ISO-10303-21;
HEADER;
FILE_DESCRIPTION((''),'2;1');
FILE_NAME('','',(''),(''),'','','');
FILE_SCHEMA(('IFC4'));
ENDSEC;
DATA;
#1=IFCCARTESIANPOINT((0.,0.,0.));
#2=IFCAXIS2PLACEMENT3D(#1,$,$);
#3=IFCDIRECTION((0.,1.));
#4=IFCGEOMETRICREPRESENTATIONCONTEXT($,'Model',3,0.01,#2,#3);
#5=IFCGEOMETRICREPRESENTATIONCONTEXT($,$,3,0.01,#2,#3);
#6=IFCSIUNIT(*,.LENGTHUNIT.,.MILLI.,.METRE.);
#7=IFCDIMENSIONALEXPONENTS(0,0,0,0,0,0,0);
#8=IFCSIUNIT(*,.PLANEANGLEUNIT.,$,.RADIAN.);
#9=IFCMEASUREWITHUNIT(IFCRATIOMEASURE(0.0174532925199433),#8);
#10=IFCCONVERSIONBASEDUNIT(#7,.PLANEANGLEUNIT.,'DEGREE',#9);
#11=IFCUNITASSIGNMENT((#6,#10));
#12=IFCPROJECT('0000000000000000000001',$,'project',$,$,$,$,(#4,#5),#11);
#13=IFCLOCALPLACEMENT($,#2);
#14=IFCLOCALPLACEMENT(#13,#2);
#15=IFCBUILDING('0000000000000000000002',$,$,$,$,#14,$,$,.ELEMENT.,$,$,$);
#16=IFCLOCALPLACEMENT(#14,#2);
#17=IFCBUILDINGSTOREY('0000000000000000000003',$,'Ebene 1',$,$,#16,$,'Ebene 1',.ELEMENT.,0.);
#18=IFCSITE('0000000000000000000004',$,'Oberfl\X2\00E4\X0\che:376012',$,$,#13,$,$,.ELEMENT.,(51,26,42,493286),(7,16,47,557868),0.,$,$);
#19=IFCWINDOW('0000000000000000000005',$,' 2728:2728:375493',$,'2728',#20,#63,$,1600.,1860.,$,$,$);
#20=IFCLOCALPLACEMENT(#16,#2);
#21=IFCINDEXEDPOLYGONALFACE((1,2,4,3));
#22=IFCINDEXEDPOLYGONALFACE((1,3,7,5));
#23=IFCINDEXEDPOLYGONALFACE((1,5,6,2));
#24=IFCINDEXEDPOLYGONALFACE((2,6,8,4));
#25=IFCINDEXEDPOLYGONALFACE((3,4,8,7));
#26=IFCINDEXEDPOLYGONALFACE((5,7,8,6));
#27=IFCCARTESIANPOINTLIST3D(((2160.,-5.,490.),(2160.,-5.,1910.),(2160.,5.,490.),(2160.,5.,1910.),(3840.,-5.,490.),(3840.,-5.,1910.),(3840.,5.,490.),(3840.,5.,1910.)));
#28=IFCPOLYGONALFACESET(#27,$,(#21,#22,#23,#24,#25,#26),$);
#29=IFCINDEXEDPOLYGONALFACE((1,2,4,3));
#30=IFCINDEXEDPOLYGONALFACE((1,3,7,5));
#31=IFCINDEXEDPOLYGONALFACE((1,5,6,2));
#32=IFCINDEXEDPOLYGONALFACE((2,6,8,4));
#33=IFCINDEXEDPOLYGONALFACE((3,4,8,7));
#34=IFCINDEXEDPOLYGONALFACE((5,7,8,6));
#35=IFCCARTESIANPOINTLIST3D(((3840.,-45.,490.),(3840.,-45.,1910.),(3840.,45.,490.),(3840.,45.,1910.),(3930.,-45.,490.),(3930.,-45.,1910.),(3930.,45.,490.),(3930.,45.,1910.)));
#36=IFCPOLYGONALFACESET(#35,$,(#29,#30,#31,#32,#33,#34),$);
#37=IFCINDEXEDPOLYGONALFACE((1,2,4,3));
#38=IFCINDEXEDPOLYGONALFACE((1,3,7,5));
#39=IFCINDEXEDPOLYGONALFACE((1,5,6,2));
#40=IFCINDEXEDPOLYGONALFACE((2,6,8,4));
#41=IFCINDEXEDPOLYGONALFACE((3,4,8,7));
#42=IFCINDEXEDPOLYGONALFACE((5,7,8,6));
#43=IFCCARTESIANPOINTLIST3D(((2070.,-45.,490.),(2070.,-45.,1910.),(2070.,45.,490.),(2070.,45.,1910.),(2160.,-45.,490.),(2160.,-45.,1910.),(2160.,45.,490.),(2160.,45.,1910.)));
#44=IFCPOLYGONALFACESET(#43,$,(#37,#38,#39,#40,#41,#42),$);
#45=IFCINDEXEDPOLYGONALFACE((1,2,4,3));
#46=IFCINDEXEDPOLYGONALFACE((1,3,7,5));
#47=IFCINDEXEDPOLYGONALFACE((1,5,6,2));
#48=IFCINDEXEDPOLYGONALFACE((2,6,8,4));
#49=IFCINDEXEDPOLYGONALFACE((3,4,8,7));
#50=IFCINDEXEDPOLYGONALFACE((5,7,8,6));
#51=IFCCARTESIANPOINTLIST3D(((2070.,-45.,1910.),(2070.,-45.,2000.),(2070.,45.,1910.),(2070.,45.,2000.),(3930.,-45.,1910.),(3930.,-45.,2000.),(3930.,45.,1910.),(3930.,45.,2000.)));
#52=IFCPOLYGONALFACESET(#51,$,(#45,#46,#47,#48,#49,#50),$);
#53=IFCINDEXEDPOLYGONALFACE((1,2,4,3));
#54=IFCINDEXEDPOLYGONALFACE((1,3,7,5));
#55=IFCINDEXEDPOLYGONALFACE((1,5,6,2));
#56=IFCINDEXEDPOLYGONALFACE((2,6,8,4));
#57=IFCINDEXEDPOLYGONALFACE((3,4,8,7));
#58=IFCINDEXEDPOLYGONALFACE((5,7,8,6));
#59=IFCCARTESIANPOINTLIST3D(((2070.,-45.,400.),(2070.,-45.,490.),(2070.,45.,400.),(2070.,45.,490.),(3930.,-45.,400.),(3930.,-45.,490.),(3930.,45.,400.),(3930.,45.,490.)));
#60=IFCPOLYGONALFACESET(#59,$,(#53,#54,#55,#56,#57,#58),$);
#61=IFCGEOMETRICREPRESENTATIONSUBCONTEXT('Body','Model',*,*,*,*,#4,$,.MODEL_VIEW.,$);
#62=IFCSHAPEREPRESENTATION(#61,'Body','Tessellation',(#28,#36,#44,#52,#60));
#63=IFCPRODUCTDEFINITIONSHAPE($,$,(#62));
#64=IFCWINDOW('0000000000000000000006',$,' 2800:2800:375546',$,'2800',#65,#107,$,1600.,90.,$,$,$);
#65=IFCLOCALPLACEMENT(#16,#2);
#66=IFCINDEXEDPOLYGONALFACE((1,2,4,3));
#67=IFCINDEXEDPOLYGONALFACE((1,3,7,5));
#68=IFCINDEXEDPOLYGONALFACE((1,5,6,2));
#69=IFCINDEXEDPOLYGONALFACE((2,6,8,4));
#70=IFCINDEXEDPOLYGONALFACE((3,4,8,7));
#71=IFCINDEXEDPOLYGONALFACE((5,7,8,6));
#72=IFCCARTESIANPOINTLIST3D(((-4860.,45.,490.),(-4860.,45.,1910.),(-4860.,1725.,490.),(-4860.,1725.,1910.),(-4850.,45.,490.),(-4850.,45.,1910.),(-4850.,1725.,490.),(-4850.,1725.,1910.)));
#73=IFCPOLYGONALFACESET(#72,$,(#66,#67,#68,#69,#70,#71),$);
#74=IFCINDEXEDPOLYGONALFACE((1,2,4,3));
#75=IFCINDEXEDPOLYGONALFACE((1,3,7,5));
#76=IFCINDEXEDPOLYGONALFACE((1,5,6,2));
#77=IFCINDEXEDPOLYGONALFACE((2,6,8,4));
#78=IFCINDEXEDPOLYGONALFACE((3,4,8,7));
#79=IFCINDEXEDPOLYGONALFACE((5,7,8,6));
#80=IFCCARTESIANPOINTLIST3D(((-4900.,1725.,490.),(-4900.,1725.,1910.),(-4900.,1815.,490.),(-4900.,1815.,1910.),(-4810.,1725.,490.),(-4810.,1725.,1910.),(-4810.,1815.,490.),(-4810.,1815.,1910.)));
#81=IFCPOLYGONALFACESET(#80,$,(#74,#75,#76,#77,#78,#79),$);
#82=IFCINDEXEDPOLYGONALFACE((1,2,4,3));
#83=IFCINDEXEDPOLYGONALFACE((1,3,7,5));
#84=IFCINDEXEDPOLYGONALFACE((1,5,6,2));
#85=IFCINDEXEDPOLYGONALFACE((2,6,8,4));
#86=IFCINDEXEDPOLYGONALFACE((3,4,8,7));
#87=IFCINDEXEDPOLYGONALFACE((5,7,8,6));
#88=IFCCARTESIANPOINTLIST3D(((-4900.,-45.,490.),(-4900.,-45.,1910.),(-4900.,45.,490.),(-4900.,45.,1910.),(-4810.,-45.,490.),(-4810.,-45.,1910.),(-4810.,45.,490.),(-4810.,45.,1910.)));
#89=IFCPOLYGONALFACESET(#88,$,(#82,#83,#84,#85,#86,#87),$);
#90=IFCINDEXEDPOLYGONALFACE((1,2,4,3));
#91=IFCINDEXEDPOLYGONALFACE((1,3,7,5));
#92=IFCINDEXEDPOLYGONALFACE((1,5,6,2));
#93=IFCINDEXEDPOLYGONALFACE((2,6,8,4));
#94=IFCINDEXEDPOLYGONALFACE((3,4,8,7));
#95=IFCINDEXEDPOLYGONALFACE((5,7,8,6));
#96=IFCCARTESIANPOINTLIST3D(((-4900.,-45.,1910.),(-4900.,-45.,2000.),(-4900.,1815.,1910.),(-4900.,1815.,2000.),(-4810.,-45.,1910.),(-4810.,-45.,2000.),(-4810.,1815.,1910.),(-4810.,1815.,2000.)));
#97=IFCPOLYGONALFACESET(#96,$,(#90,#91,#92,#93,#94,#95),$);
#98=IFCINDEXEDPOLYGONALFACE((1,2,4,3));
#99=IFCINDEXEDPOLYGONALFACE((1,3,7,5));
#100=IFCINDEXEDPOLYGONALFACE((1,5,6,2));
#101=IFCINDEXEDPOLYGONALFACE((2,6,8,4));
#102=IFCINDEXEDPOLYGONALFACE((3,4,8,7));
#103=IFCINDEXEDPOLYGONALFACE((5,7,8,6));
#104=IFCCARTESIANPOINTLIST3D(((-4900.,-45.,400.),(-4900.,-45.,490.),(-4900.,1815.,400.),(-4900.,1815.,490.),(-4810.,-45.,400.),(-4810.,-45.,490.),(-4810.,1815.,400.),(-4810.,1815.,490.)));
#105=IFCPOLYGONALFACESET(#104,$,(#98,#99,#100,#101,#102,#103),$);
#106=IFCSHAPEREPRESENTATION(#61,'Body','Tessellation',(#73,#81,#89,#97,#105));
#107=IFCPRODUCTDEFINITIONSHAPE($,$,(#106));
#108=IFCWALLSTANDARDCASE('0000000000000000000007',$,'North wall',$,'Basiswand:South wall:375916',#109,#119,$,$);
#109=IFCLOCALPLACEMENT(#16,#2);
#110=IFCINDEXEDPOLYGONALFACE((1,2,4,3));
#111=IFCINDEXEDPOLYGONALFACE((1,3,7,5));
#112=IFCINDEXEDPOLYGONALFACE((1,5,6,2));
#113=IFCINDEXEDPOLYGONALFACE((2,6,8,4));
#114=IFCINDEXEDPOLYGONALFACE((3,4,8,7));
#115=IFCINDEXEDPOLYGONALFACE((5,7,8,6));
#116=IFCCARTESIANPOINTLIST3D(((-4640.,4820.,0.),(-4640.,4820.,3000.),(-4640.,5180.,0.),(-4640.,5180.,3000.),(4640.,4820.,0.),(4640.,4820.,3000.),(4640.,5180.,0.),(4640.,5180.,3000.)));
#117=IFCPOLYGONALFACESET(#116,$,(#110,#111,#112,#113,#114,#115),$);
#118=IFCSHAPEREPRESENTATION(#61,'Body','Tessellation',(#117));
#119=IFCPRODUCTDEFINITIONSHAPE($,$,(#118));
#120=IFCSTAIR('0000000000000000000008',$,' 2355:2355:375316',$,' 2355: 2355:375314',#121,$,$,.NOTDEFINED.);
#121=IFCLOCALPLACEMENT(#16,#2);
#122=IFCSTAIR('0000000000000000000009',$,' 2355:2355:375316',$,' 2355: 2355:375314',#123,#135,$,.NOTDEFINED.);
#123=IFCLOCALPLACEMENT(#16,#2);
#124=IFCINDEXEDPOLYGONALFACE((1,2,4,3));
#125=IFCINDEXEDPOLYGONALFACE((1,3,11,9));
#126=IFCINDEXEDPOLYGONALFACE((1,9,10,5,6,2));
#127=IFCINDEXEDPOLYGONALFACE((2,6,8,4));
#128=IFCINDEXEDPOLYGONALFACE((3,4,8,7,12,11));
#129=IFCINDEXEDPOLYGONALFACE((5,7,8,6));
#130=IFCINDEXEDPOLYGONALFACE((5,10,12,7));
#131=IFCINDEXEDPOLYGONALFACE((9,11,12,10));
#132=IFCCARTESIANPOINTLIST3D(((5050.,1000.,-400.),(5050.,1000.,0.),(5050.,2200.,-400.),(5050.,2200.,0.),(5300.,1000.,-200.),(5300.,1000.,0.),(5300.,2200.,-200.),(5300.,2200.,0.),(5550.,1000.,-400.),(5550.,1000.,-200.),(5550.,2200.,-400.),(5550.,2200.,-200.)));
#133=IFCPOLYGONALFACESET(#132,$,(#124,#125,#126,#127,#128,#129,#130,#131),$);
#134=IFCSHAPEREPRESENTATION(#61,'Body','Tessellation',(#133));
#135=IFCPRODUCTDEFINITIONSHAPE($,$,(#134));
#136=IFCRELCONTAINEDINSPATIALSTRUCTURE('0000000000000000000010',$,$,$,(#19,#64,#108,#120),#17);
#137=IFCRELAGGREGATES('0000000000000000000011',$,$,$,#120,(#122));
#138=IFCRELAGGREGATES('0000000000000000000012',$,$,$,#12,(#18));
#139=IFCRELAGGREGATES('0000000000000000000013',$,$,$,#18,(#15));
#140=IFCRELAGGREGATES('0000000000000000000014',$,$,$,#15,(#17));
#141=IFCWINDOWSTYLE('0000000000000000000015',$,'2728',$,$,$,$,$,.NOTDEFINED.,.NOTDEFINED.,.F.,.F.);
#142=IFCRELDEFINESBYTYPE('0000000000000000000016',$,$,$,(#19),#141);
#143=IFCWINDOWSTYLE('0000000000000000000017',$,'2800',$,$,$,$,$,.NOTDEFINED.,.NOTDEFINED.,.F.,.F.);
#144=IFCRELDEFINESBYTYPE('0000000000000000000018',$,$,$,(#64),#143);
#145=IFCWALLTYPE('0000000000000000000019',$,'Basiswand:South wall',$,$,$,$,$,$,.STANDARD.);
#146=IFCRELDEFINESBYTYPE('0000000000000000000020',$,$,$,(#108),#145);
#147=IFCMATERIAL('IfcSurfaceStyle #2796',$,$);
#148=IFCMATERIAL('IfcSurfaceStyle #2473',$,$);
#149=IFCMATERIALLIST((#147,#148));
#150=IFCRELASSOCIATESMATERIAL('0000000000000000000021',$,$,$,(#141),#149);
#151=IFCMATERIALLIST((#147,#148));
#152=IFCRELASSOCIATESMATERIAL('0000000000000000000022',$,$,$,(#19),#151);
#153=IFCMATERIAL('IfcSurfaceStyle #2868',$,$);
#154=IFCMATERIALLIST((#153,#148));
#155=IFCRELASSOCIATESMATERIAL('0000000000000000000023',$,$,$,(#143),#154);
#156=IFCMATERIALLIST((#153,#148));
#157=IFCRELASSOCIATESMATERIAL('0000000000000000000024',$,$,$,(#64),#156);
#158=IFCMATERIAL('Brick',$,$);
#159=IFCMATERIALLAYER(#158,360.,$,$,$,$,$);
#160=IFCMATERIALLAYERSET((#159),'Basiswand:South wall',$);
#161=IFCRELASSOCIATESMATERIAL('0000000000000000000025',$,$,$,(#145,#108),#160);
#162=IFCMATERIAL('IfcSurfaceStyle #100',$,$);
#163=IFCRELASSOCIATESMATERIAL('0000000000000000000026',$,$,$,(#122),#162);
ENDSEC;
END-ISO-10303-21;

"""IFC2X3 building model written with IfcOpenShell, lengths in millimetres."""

from ifc_helpers import new_model, entity, si_unit, converted_unit, direction, frame, frame_2d, origin, origin_2d_with_axis, place, context, subcontext, project, spatial, polyline, rectangle, outline, extrude, source, transform, mapped, material, material_list, layer, layer_set, layer_usage, type_object, type_shapes, element, aggregate, save


model = new_model("IFC2X3")

# Units and contexts
model_context = context("Model", 3, precision=0.01, world=origin(), true_north=direction((0.0, 1.0)))
context_of_model = context(None, 3, precision=0.01, world=origin(), true_north=direction((0.0, 1.0)))
body_context = subcontext(model_context, "Body", "Model", "MODEL_VIEW")
ifc_project = project(units=[si_unit("LENGTHUNIT", "METRE", prefix="MILLI"), converted_unit("PLANEANGLEUNIT", "DEGREE", entity("IfcRatioMeasure", 0.0174532925199433), si_unit("PLANEANGLEUNIT", "RADIAN"), dimensions=[0, 0, 0, 0, 0, 0, 0])], contexts=[model_context, context_of_model])

# Site, building, storey
site_placement = place(None, origin())
site = spatial("IfcSite", under=ifc_project, at=site_placement, Name="Oberfläche:376012", CompositionType="ELEMENT", RefLatitude=(51, 26, 42, 493286), RefLongitude=(7, 16, 47, 557868), RefElevation=0.0)
building_placement = place(site_placement, origin())
building = spatial("IfcBuilding", under=site, at=building_placement, CompositionType="ELEMENT")
storey_placement = place(building_placement, origin())
storey = spatial("IfcBuildingStorey", under=building, at=storey_placement, Name="Ebene 1", LongName="Ebene 1", CompositionType="ELEMENT", Elevation=0.0)

# Shared definitions
ifc_material_1 = material(Name="IfcSurfaceStyle #100")

# Windows
ifc_material_2 = material(Name="IfcSurfaceStyle #2473")
ifc_material_3 = material(Name="IfcSurfaceStyle #2796")
ifc_material_list_1 = material_list([ifc_material_3, ifc_material_2])
ifc_material_list_2 = material_list([ifc_material_3, ifc_material_2])
window_style_1 = type_object("IfcWindowStyle", Name="2728", ConstructionType="NOTDEFINED", OperationType="NOTDEFINED", ParameterTakesPrecedence=False, Sizeable=False, material=ifc_material_list_2)
shared_shape_1 = source(origin(), body_context, "Body", "SweptSolid", [
    extrude(rectangle(XDim=10.0, YDim=1680.0, at=frame_2d((0.0, 0.0), x_axis=(1.0, 0.0))), frame((3000.0, 0.0, 490.0), z_axis=(0.0, 0.0, 1.0), x_axis=(0.0, 1.0, 0.0)), (0.0, 0.0, 1.0), 1420.0),
    extrude(rectangle(XDim=90.0, YDim=90.0, at=origin_2d_with_axis()), frame((3885.0, 0.0, 490.0), z_axis=(0.0, 0.0, 1.0), x_axis=(0.0, 1.0, 0.0)), (0.0, 0.0, 1.0), 1420.0),
    extrude(rectangle(XDim=90.0, YDim=90.0, at=origin_2d_with_axis()), frame((2115.0, 0.0, 490.0), z_axis=(0.0, 0.0, 1.0), x_axis=(0.0, 1.0, 0.0)), (0.0, 0.0, 1.0), 1420.0),
    extrude(rectangle(XDim=90.0, YDim=1860.0, at=frame_2d((0.0, 0.0), x_axis=(1.0, 0.0))), frame((3000.0, 0.0, 1910.0), z_axis=(0.0, 0.0, 1.0), x_axis=(0.0, 1.0, 0.0)), (0.0, 0.0, 1.0), 90.0),
    extrude(rectangle(XDim=90.0, YDim=1860.0, at=frame_2d((0.0, 0.0), x_axis=(1.0, 0.0))), frame((3000.0, 0.0, 400.0), z_axis=(0.0, 0.0, 1.0), x_axis=(0.0, 1.0, 0.0)), (0.0, 0.0, 1.0), 90.0),
])
type_shapes(window_style_1, [shared_shape_1])
window_1_placement = place(storey_placement, origin())
element("IfcWindow", 1, at=window_1_placement, inside=storey, type_object=window_style_1, material=ifc_material_list_1, Name=" 2728:2728:375493", ObjectType="2728", OverallHeight=1600.0, OverallWidth=1860.0, context=body_context, shape_type="MappedRepresentation", body=[
    mapped(shared_shape_1, transform((0.0, 0.0, 0.0), scale=1.0)),
])
ifc_material_4 = material(Name="IfcSurfaceStyle #2868")
ifc_material_list_3 = material_list([ifc_material_4, ifc_material_2])
ifc_material_list_4 = material_list([ifc_material_4, ifc_material_2])
window_style_2 = type_object("IfcWindowStyle", Name="2800", ConstructionType="NOTDEFINED", OperationType="NOTDEFINED", ParameterTakesPrecedence=False, Sizeable=False, material=ifc_material_list_4)
shared_shape_2 = source(origin(), body_context, "Body", "SweptSolid", [
    extrude(rectangle(XDim=10.0, YDim=1680.0, at=origin_2d_with_axis()), frame((-4855.0, 885.0, 490.0), z_axis=(0.0, 0.0, 1.0), x_axis=(-1.0, 0.0, 0.0)), (0.0, 0.0, 1.0), 1420.0),
    extrude(rectangle(XDim=90.0, YDim=90.0, at=frame_2d((0.0, 0.0), x_axis=(1.0, 0.0))), frame((-4855.0, 1770.0, 490.0), z_axis=(0.0, 0.0, 1.0), x_axis=(-1.0, 0.0, 0.0)), (0.0, 0.0, 1.0), 1420.0),
    extrude(rectangle(XDim=90.0, YDim=90.0, at=origin_2d_with_axis()), frame((-4855.0, 0.0, 490.0), z_axis=(0.0, 0.0, 1.0), x_axis=(-1.0, 0.0, 0.0)), (0.0, 0.0, 1.0), 1420.0),
    extrude(rectangle(XDim=90.0, YDim=1860.0, at=origin_2d_with_axis()), frame((-4855.0, 885.0, 1910.0), z_axis=(0.0, 0.0, 1.0), x_axis=(-1.0, 0.0, 0.0)), (0.0, 0.0, 1.0), 90.0),
    extrude(rectangle(XDim=90.0, YDim=1860.0, at=origin_2d_with_axis()), frame((-4855.0, 885.0, 400.0), z_axis=(0.0, 0.0, 1.0), x_axis=(-1.0, 0.0, 0.0)), (0.0, 0.0, 1.0), 90.0),
])
type_shapes(window_style_2, [shared_shape_2])
window_2_placement = place(storey_placement, origin())
element("IfcWindow", 2, at=window_2_placement, inside=storey, type_object=window_style_2, material=ifc_material_list_3, Name=" 2800:2800:375546", ObjectType="2800", OverallHeight=1600.0, OverallWidth=90.0, context=body_context, shape_type="MappedRepresentation", body=[
    mapped(shared_shape_2, transform((0.0, 0.0, 0.0), scale=1.0)),
])

# Shared definitions
ifc_material_5 = material(Name="Brick")
ifc_layer = layer(ifc_material_5, 360.0)
ifc_layer_set = layer_set([ifc_layer], Name="Basiswand:South wall")
wall_type = type_object("IfcWallType", Name="Basiswand:South wall", PredefinedType="STANDARD", material=ifc_layer_set)

# Wall
ifc_layer_usage_1 = layer_usage(ifc_layer_set, "AXIS2", "NEGATIVE", 180.0)
wall_1_placement = place(storey_placement, frame((4640.0, 5000.0, 0.0), z_axis=(0.0, 0.0, 1.0), x_axis=(-1.0, 0.0, 0.0)))
element("IfcWallStandardCase", 3, at=wall_1_placement, inside=storey, type_object=wall_type, material=ifc_layer_usage_1, Name="North wall", ObjectType="Basiswand:South wall:375916", context=body_context, shape_type="SweptSolid", body=[
    extrude(rectangle(XDim=9280.0, YDim=360.0, at=frame_2d((4640.0, 0.0), x_axis=(-1.0, 0.0))), origin(), (0.0, 0.0, 1.0), 3000.0),
])

# Stairs
stair_1_placement = place(storey_placement, origin())
stair_1 = element("IfcStair", 4, at=stair_1_placement, inside=storey, Name=" 2355:2355:375316", ObjectType=" 2355: 2355:375314", ShapeType="NOTDEFINED")
stair_2_placement = place(stair_1_placement, origin())
stair_2 = element("IfcStair", 5, at=stair_2_placement, material=ifc_material_1, Name=" 2355:2355:375316", ObjectType=" 2355: 2355:375314", ShapeType="NOTDEFINED", context=body_context, shape_type="SweptSolid", body=[
    extrude(outline(polyline([(-200.0, 0.0), (-200.0, -250.0), (200.0, -250.0), (200.0, 250.0), (0.0, 250.0), (0.0, 0.0), (-200.0, 0.0)])), frame((5300.0, 1000.0, -200.0), z_axis=(0.0, -1.0, 0.0), x_axis=(0.0, 0.0, -1.0)), (0.0, 0.0, -1.0), 1200.0),
])
aggregate(stair_1, [stair_2])

save(model, "model.ifc")
